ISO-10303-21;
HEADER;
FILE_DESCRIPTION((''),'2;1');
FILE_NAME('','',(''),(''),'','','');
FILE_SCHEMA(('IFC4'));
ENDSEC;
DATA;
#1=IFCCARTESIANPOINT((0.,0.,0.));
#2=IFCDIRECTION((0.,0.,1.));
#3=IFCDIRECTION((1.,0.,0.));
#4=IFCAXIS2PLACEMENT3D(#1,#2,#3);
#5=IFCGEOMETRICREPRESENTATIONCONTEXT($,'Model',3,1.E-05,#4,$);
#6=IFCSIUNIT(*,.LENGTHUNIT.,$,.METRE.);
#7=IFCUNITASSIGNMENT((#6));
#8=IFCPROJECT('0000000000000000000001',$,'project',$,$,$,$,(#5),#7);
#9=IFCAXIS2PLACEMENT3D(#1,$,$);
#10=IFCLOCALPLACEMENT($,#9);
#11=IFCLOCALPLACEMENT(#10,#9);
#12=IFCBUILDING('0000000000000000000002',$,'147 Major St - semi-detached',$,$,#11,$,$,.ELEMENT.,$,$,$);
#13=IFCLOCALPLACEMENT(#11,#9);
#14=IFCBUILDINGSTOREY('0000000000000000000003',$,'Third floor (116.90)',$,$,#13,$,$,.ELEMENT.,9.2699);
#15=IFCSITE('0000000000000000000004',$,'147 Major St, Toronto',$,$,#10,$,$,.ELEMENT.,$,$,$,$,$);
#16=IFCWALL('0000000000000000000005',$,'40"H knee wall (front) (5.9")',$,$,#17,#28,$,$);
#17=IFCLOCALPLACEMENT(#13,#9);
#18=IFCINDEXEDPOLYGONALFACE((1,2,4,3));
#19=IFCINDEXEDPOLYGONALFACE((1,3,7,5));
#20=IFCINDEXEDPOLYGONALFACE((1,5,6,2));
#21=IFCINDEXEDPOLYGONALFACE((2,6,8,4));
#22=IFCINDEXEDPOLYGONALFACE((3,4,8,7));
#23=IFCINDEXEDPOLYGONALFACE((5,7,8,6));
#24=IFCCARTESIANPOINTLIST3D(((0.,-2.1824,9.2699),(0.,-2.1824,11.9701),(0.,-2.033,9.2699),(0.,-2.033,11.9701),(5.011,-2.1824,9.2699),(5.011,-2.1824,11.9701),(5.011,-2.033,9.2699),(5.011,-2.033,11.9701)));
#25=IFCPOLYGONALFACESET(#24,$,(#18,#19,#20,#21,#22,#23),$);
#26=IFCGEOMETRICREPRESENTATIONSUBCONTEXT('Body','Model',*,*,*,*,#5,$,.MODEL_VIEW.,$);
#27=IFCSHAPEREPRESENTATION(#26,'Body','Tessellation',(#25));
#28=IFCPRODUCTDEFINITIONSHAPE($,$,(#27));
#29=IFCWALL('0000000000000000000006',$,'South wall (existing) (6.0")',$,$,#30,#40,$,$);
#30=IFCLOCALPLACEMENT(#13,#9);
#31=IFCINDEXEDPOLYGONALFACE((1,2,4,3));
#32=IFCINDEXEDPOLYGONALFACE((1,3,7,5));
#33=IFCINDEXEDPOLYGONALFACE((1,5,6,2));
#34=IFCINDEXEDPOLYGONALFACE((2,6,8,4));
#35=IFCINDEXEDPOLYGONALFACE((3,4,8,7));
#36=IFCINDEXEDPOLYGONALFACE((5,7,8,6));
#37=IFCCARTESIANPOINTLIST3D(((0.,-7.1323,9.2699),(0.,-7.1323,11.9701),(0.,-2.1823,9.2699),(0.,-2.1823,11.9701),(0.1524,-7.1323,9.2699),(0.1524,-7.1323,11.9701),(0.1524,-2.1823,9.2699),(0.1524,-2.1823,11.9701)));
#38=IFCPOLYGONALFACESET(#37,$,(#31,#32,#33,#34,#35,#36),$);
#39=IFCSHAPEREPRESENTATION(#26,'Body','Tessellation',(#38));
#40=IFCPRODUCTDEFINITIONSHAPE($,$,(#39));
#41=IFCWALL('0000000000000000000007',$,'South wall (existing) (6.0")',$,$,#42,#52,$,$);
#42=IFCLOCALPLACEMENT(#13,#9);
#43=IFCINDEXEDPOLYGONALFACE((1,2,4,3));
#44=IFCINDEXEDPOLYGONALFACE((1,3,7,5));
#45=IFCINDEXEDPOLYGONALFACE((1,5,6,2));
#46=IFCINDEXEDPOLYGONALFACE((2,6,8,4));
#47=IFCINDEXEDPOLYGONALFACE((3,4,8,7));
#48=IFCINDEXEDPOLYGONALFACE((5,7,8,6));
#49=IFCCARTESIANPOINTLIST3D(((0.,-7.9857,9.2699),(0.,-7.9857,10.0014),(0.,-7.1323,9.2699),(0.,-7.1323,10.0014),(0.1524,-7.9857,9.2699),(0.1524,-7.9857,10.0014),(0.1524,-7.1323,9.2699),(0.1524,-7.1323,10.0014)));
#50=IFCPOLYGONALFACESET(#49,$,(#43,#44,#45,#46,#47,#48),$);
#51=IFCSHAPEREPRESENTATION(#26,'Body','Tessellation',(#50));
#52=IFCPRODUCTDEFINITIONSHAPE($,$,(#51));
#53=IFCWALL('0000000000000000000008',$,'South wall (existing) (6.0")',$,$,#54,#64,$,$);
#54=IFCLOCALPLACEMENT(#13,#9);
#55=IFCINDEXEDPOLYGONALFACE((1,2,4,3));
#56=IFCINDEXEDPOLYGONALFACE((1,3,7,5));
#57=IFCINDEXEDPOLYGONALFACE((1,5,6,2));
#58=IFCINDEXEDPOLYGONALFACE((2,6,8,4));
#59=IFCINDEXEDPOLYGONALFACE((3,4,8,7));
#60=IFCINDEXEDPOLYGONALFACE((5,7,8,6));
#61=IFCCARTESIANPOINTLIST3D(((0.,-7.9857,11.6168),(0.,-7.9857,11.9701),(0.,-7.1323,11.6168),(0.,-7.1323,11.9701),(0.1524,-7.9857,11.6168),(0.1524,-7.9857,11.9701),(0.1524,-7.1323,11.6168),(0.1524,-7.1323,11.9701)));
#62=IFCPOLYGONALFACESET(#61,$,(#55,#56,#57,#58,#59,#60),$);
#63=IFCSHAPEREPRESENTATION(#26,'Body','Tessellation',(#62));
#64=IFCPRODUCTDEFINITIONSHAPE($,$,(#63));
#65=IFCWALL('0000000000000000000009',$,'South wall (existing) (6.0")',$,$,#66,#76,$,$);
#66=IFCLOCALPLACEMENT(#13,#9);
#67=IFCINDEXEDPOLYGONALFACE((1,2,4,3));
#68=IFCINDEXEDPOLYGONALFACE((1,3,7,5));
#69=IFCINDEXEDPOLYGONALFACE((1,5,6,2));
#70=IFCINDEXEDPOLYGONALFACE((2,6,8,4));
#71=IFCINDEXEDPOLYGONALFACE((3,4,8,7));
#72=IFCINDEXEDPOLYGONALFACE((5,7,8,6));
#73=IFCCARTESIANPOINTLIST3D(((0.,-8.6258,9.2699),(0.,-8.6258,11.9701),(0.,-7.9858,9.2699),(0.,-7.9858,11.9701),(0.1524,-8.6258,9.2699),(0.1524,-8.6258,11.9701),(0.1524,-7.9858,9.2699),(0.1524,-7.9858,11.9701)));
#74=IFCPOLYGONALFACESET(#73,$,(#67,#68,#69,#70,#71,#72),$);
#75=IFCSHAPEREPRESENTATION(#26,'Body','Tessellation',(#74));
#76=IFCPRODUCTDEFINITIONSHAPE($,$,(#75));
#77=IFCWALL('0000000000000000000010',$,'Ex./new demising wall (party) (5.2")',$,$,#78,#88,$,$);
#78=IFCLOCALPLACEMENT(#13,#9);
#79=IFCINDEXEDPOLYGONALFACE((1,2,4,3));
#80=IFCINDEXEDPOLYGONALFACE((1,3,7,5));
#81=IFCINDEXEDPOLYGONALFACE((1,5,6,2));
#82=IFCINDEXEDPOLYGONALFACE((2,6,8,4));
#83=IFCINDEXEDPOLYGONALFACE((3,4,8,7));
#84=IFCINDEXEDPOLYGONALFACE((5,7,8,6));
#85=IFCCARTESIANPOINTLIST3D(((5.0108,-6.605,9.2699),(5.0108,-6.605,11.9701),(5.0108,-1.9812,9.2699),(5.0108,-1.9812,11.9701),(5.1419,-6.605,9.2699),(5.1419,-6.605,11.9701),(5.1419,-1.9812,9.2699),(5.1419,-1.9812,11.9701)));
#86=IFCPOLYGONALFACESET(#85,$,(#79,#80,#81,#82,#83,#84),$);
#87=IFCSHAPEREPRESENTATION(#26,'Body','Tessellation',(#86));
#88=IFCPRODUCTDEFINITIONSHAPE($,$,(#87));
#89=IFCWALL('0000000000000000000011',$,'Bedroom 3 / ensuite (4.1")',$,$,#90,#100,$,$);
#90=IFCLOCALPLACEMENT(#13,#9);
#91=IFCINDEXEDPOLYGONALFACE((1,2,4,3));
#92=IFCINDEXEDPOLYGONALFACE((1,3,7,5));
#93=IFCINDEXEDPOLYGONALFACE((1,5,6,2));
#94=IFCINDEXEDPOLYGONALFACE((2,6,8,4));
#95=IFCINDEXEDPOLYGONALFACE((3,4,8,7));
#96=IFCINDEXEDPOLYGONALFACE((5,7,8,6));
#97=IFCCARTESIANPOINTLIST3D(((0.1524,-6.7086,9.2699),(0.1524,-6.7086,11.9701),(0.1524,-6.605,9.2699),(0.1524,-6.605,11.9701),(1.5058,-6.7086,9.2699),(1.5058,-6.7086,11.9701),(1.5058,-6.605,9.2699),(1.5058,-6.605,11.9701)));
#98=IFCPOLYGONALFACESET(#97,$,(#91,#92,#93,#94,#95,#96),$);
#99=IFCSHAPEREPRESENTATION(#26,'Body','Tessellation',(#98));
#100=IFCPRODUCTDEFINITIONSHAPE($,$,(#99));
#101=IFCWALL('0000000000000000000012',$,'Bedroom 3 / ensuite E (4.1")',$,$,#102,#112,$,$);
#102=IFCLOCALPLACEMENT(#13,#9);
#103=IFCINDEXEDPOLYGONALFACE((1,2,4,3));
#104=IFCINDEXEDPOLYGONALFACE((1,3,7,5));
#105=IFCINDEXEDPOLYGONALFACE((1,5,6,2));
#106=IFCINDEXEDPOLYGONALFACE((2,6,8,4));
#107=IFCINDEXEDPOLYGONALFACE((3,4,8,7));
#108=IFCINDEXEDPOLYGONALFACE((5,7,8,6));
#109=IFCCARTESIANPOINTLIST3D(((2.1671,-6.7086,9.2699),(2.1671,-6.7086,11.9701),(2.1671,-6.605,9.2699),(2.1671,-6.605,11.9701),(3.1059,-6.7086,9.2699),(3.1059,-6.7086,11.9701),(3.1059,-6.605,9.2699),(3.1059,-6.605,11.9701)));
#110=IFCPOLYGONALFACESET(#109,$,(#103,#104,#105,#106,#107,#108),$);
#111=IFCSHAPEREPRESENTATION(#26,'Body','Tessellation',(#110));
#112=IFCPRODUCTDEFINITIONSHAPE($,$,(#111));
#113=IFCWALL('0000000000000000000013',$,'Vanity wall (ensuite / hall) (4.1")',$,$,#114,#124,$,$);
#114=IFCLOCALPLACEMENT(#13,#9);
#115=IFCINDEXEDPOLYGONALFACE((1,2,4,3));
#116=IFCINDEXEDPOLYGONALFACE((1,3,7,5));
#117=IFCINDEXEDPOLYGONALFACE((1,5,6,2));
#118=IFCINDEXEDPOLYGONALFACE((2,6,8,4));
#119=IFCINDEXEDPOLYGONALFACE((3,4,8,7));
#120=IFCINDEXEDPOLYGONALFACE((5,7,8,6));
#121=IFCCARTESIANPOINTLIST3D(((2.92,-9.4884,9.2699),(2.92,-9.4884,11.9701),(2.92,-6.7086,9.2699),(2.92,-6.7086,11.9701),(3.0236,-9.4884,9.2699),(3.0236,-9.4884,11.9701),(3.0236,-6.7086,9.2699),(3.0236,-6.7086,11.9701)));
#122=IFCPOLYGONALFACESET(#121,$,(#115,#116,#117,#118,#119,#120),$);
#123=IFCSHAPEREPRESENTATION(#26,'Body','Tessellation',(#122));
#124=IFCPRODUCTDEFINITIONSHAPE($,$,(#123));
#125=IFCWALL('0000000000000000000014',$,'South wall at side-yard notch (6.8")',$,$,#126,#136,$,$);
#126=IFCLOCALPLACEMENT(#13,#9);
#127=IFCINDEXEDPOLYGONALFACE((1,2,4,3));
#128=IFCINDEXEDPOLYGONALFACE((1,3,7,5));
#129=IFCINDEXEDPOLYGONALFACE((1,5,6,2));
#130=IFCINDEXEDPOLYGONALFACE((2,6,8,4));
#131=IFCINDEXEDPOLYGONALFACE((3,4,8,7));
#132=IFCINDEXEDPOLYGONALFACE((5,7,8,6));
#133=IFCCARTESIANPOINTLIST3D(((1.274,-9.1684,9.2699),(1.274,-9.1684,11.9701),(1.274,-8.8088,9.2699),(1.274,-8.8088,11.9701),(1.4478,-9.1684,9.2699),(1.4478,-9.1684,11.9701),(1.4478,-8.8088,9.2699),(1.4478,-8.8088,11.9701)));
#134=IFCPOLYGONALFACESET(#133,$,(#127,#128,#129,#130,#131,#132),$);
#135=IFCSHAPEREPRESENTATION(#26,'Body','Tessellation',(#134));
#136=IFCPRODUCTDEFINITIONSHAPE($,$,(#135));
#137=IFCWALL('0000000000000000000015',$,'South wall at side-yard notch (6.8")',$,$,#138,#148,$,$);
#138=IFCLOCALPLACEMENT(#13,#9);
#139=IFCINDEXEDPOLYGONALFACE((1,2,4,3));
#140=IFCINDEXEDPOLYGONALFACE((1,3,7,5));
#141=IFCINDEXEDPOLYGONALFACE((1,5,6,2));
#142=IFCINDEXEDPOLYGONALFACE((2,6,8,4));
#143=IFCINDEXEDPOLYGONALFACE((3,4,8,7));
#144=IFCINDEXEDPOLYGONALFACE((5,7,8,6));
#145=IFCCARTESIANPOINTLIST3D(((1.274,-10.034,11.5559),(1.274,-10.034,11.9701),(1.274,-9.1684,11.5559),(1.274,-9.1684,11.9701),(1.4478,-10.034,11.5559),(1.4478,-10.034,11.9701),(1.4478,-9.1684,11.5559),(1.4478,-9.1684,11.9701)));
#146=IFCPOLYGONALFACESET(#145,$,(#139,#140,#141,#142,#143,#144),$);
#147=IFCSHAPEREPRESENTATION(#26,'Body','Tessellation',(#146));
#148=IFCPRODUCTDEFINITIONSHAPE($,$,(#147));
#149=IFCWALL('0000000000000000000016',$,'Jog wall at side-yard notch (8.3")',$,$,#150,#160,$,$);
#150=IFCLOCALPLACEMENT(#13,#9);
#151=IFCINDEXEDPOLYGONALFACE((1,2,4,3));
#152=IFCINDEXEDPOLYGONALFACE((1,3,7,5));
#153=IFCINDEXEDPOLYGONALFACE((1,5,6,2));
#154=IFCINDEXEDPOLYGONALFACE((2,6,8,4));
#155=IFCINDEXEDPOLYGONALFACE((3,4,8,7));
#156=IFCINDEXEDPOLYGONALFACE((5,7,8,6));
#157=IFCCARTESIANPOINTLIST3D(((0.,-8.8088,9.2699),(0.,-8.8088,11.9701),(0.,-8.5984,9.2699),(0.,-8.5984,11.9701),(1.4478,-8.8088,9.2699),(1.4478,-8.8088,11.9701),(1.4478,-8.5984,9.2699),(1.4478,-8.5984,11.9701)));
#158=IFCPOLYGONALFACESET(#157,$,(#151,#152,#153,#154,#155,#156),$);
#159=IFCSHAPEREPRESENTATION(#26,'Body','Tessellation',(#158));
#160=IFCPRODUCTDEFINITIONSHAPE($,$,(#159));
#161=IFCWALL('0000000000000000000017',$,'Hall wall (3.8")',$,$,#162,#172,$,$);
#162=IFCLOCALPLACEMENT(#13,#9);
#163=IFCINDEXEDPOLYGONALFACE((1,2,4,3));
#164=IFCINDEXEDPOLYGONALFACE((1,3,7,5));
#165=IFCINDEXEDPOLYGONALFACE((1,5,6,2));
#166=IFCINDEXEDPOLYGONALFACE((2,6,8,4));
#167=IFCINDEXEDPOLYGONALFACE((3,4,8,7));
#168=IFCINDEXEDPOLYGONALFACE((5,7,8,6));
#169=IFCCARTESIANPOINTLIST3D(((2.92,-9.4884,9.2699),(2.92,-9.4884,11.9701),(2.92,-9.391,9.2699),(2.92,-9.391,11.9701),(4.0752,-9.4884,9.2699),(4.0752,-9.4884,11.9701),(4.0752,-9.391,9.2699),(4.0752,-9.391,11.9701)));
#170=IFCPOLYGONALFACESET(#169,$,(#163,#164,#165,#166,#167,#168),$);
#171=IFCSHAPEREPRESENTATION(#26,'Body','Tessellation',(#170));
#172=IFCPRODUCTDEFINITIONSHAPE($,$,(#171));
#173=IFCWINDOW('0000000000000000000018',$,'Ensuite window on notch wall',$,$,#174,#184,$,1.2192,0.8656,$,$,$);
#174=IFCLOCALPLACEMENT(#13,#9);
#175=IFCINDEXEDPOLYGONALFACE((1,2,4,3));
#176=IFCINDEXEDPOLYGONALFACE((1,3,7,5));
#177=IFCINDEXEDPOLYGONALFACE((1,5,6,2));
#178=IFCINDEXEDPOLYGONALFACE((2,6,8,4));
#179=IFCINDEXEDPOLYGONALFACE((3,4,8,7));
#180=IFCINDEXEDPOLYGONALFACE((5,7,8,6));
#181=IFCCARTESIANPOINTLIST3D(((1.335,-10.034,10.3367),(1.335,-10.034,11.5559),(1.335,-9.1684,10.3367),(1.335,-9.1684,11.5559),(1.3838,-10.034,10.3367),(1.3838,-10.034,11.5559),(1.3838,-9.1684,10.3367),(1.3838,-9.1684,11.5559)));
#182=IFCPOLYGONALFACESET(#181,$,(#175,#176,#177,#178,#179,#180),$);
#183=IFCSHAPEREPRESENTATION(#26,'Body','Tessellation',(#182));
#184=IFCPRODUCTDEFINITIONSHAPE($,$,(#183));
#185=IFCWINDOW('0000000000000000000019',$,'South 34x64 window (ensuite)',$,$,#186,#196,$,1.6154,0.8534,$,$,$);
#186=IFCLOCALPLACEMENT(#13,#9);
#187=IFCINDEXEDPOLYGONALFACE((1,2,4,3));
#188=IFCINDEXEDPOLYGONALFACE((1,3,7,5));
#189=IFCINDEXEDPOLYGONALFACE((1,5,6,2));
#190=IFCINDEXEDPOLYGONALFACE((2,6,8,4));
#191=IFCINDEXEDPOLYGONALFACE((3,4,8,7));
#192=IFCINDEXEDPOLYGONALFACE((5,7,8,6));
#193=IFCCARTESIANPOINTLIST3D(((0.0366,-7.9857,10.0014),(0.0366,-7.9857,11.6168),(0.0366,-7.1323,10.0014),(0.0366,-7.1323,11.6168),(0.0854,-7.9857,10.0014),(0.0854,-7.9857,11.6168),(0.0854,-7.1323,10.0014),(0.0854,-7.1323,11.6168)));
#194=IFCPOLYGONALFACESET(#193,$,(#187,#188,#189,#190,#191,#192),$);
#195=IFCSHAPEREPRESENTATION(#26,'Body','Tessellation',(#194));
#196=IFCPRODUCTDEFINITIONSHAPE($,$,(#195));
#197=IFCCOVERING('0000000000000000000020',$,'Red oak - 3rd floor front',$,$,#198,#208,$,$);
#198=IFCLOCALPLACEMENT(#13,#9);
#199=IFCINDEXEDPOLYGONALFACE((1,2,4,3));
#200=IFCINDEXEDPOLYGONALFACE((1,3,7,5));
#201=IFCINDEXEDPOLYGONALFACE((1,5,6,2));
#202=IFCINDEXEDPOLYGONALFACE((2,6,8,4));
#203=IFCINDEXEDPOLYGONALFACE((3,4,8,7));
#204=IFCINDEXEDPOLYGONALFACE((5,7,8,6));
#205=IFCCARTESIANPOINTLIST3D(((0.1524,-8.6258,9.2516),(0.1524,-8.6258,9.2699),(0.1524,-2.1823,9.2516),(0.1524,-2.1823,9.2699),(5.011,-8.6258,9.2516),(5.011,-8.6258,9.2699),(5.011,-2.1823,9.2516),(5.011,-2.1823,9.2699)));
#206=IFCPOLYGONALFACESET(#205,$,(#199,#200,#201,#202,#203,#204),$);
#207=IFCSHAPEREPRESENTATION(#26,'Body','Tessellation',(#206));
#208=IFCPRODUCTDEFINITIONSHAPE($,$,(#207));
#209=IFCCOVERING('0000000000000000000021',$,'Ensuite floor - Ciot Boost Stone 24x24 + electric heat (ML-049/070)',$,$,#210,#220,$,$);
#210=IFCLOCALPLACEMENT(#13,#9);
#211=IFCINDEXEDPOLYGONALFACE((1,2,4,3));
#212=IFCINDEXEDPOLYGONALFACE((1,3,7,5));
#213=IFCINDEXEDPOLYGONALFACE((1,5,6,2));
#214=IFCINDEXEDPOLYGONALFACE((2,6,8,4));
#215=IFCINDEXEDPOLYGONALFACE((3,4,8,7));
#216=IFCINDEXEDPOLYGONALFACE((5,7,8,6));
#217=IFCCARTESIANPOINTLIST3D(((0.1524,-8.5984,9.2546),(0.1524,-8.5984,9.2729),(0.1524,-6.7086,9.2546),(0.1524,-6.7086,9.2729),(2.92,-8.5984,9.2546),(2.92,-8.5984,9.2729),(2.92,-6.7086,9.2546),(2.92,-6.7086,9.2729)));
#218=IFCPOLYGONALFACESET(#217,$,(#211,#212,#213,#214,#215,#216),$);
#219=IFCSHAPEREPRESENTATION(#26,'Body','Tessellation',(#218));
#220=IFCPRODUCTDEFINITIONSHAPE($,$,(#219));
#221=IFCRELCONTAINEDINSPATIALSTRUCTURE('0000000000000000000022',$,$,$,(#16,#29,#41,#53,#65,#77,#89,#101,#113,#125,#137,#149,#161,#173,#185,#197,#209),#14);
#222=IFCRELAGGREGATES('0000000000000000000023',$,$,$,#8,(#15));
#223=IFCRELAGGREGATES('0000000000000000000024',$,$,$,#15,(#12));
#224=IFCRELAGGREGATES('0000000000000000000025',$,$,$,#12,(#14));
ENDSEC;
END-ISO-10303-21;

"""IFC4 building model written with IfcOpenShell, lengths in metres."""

from ifc_helpers import new_model, si_unit, frame, origin, origin_with_axes, place, context, subcontext, project, spatial, rectangle, extrude, element, save


model = new_model("IFC4")

# Units and contexts
model_context = context("Model", 3, precision=1e-05, world=origin_with_axes())
body_context = subcontext(model_context, "Body", "Model", "MODEL_VIEW")
ifc_project = project(units=[si_unit("LENGTHUNIT", "METRE")], contexts=[model_context])

# Site, building, storey
site_placement = place(None, origin())
site = spatial("IfcSite", under=ifc_project, at=site_placement, Name="147 Major St, Toronto", CompositionType="ELEMENT")
building_placement = place(site_placement, origin())
building = spatial("IfcBuilding", under=site, at=building_placement, Name="147 Major St - semi-detached", CompositionType="ELEMENT")
storey_placement = place(building_placement, origin())
storey = spatial("IfcBuildingStorey", under=building, at=storey_placement, Name="Third floor (116.90)", CompositionType="ELEMENT", Elevation=9.2699)

# Walls
wall_1_placement = place(storey_placement, frame((2.5055, -2.1077, 9.2699)))
element("IfcWall", 1, at=wall_1_placement, inside=storey, Name="40\"H knee wall (front) (5.9\")", context=body_context, shape_type="SweptSolid", body=[
    extrude(rectangle(XDim=5.0109, YDim=0.1494), origin_with_axes(), (0.0, 0.0, 1.0), 2.7002),
])
wall_2_placement = place(storey_placement, frame((0.0762, -4.6573, 9.2699)))
element("IfcWall", 2, at=wall_2_placement, inside=storey, Name="South wall (existing) (6.0\")", context=body_context, shape_type="SweptSolid", body=[
    extrude(rectangle(XDim=0.1524, YDim=4.95), origin_with_axes(), (0.0, 0.0, 1.0), 2.7002),
])
wall_3_placement = place(storey_placement, frame((0.0762, -7.559, 9.2699)))
element("IfcWall", 3, at=wall_3_placement, inside=storey, Name="South wall (existing) (6.0\")", context=body_context, shape_type="SweptSolid", body=[
    extrude(rectangle(XDim=0.1524, YDim=0.8534), origin_with_axes(), (0.0, 0.0, 1.0), 0.7315),
])
wall_4_placement = place(storey_placement, frame((0.0762, -7.559, 11.6168)))
element("IfcWall", 4, at=wall_4_placement, inside=storey, Name="South wall (existing) (6.0\")", context=body_context, shape_type="SweptSolid", body=[
    extrude(rectangle(XDim=0.1524, YDim=0.8534), origin_with_axes(), (0.0, 0.0, 1.0), 0.3533),
])
wall_5_placement = place(storey_placement, frame((0.0762, -8.3058, 9.2699)))
element("IfcWall", 5, at=wall_5_placement, inside=storey, Name="South wall (existing) (6.0\")", context=body_context, shape_type="SweptSolid", body=[
    extrude(rectangle(XDim=0.1524, YDim=0.6401), origin_with_axes(), (0.0, 0.0, 1.0), 2.7002),
])
wall_6_placement = place(storey_placement, frame((5.0764, -4.2931, 9.2699)))
element("IfcWall", 6, at=wall_6_placement, inside=storey, Name="Ex./new demising wall (party) (5.2\")", context=body_context, shape_type="SweptSolid", body=[
    extrude(rectangle(XDim=0.1311, YDim=4.6238), origin_with_axes(), (0.0, 0.0, 1.0), 2.7002),
])
wall_7_placement = place(storey_placement, frame((0.8291, -6.6568, 9.2699)))
element("IfcWall", 7, at=wall_7_placement, inside=storey, Name="Bedroom 3 / ensuite (4.1\")", context=body_context, shape_type="SweptSolid", body=[
    extrude(rectangle(XDim=1.3533, YDim=0.1036), origin_with_axes(), (0.0, 0.0, 1.0), 2.7002),
])
wall_8_placement = place(storey_placement, frame((2.6365, -6.6568, 9.2699)))
element("IfcWall", 8, at=wall_8_placement, inside=storey, Name="Bedroom 3 / ensuite E (4.1\")", context=body_context, shape_type="SweptSolid", body=[
    extrude(rectangle(XDim=0.9388, YDim=0.1036), origin_with_axes(), (0.0, 0.0, 1.0), 2.7002),
])
wall_9_placement = place(storey_placement, frame((2.9718, -8.0985, 9.2699)))
element("IfcWall", 9, at=wall_9_placement, inside=storey, Name="Vanity wall (ensuite / hall) (4.1\")", context=body_context, shape_type="SweptSolid", body=[
    extrude(rectangle(XDim=0.1036, YDim=2.7798), origin_with_axes(), (0.0, 0.0, 1.0), 2.7002),
])
wall_10_placement = place(storey_placement, frame((1.3609, -8.9886, 9.2699)))
element("IfcWall", 10, at=wall_10_placement, inside=storey, Name="South wall at side-yard notch (6.8\")", context=body_context, shape_type="SweptSolid", body=[
    extrude(rectangle(XDim=0.1737, YDim=0.3597), origin_with_axes(), (0.0, 0.0, 1.0), 2.7002),
])
wall_11_placement = place(storey_placement, frame((1.3609, -9.6012, 11.5559)))
element("IfcWall", 11, at=wall_11_placement, inside=storey, Name="South wall at side-yard notch (6.8\")", context=body_context, shape_type="SweptSolid", body=[
    extrude(rectangle(XDim=0.1737, YDim=0.8656), origin_with_axes(), (0.0, 0.0, 1.0), 0.4142),
])
wall_12_placement = place(storey_placement, frame((0.7239, -8.7036, 9.2699)))
element("IfcWall", 12, at=wall_12_placement, inside=storey, Name="Jog wall at side-yard notch (8.3\")", context=body_context, shape_type="SweptSolid", body=[
    extrude(rectangle(XDim=1.4478, YDim=0.2103), origin_with_axes(), (0.0, 0.0, 1.0), 2.7002),
])
wall_13_placement = place(storey_placement, frame((3.4976, -9.4397, 9.2699)))
element("IfcWall", 13, at=wall_13_placement, inside=storey, Name="Hall wall (3.8\")", context=body_context, shape_type="SweptSolid", body=[
    extrude(rectangle(XDim=1.1552, YDim=0.0975), origin_with_axes(), (0.0, 0.0, 1.0), 2.7002),
])

# Windows
window_1_placement = place(storey_placement, frame((1.3594, -9.6012, 10.3367)))
element("IfcWindow", 14, at=window_1_placement, inside=storey, Name="Ensuite window on notch wall", OverallHeight=1.2192, OverallWidth=0.8656, context=body_context, shape_type="SweptSolid", body=[
    extrude(rectangle(XDim=0.0488, YDim=0.8656), origin_with_axes(), (0.0, 0.0, 1.0), 1.2192),
])
window_2_placement = place(storey_placement, frame((0.061, -7.559, 10.0014)))
element("IfcWindow", 15, at=window_2_placement, inside=storey, Name="South 34x64 window (ensuite)", OverallHeight=1.6154, OverallWidth=0.8534, context=body_context, shape_type="SweptSolid", body=[
    extrude(rectangle(XDim=0.0488, YDim=0.8534), origin_with_axes(), (0.0, 0.0, 1.0), 1.6154),
])

# Coverings
covering_1_placement = place(storey_placement, frame((2.5817, -5.4041, 9.2516)))
element("IfcCovering", 16, at=covering_1_placement, inside=storey, Name="Red oak - 3rd floor front", context=body_context, shape_type="SweptSolid", body=[
    extrude(rectangle(XDim=4.8585, YDim=6.4435), origin_with_axes(), (0.0, 0.0, 1.0), 0.0183),
])
covering_2_placement = place(storey_placement, frame((1.5362, -7.6535, 9.2546)))
element("IfcCovering", 17, at=covering_2_placement, inside=storey, Name="Ensuite floor - Ciot Boost Stone 24x24 + electric heat (ML-049/070)", context=body_context, shape_type="SweptSolid", body=[
    extrude(rectangle(XDim=2.7676, YDim=1.8898), origin_with_axes(), (0.0, 0.0, 1.0), 0.0183),
])

save(model, "model.ifc")
